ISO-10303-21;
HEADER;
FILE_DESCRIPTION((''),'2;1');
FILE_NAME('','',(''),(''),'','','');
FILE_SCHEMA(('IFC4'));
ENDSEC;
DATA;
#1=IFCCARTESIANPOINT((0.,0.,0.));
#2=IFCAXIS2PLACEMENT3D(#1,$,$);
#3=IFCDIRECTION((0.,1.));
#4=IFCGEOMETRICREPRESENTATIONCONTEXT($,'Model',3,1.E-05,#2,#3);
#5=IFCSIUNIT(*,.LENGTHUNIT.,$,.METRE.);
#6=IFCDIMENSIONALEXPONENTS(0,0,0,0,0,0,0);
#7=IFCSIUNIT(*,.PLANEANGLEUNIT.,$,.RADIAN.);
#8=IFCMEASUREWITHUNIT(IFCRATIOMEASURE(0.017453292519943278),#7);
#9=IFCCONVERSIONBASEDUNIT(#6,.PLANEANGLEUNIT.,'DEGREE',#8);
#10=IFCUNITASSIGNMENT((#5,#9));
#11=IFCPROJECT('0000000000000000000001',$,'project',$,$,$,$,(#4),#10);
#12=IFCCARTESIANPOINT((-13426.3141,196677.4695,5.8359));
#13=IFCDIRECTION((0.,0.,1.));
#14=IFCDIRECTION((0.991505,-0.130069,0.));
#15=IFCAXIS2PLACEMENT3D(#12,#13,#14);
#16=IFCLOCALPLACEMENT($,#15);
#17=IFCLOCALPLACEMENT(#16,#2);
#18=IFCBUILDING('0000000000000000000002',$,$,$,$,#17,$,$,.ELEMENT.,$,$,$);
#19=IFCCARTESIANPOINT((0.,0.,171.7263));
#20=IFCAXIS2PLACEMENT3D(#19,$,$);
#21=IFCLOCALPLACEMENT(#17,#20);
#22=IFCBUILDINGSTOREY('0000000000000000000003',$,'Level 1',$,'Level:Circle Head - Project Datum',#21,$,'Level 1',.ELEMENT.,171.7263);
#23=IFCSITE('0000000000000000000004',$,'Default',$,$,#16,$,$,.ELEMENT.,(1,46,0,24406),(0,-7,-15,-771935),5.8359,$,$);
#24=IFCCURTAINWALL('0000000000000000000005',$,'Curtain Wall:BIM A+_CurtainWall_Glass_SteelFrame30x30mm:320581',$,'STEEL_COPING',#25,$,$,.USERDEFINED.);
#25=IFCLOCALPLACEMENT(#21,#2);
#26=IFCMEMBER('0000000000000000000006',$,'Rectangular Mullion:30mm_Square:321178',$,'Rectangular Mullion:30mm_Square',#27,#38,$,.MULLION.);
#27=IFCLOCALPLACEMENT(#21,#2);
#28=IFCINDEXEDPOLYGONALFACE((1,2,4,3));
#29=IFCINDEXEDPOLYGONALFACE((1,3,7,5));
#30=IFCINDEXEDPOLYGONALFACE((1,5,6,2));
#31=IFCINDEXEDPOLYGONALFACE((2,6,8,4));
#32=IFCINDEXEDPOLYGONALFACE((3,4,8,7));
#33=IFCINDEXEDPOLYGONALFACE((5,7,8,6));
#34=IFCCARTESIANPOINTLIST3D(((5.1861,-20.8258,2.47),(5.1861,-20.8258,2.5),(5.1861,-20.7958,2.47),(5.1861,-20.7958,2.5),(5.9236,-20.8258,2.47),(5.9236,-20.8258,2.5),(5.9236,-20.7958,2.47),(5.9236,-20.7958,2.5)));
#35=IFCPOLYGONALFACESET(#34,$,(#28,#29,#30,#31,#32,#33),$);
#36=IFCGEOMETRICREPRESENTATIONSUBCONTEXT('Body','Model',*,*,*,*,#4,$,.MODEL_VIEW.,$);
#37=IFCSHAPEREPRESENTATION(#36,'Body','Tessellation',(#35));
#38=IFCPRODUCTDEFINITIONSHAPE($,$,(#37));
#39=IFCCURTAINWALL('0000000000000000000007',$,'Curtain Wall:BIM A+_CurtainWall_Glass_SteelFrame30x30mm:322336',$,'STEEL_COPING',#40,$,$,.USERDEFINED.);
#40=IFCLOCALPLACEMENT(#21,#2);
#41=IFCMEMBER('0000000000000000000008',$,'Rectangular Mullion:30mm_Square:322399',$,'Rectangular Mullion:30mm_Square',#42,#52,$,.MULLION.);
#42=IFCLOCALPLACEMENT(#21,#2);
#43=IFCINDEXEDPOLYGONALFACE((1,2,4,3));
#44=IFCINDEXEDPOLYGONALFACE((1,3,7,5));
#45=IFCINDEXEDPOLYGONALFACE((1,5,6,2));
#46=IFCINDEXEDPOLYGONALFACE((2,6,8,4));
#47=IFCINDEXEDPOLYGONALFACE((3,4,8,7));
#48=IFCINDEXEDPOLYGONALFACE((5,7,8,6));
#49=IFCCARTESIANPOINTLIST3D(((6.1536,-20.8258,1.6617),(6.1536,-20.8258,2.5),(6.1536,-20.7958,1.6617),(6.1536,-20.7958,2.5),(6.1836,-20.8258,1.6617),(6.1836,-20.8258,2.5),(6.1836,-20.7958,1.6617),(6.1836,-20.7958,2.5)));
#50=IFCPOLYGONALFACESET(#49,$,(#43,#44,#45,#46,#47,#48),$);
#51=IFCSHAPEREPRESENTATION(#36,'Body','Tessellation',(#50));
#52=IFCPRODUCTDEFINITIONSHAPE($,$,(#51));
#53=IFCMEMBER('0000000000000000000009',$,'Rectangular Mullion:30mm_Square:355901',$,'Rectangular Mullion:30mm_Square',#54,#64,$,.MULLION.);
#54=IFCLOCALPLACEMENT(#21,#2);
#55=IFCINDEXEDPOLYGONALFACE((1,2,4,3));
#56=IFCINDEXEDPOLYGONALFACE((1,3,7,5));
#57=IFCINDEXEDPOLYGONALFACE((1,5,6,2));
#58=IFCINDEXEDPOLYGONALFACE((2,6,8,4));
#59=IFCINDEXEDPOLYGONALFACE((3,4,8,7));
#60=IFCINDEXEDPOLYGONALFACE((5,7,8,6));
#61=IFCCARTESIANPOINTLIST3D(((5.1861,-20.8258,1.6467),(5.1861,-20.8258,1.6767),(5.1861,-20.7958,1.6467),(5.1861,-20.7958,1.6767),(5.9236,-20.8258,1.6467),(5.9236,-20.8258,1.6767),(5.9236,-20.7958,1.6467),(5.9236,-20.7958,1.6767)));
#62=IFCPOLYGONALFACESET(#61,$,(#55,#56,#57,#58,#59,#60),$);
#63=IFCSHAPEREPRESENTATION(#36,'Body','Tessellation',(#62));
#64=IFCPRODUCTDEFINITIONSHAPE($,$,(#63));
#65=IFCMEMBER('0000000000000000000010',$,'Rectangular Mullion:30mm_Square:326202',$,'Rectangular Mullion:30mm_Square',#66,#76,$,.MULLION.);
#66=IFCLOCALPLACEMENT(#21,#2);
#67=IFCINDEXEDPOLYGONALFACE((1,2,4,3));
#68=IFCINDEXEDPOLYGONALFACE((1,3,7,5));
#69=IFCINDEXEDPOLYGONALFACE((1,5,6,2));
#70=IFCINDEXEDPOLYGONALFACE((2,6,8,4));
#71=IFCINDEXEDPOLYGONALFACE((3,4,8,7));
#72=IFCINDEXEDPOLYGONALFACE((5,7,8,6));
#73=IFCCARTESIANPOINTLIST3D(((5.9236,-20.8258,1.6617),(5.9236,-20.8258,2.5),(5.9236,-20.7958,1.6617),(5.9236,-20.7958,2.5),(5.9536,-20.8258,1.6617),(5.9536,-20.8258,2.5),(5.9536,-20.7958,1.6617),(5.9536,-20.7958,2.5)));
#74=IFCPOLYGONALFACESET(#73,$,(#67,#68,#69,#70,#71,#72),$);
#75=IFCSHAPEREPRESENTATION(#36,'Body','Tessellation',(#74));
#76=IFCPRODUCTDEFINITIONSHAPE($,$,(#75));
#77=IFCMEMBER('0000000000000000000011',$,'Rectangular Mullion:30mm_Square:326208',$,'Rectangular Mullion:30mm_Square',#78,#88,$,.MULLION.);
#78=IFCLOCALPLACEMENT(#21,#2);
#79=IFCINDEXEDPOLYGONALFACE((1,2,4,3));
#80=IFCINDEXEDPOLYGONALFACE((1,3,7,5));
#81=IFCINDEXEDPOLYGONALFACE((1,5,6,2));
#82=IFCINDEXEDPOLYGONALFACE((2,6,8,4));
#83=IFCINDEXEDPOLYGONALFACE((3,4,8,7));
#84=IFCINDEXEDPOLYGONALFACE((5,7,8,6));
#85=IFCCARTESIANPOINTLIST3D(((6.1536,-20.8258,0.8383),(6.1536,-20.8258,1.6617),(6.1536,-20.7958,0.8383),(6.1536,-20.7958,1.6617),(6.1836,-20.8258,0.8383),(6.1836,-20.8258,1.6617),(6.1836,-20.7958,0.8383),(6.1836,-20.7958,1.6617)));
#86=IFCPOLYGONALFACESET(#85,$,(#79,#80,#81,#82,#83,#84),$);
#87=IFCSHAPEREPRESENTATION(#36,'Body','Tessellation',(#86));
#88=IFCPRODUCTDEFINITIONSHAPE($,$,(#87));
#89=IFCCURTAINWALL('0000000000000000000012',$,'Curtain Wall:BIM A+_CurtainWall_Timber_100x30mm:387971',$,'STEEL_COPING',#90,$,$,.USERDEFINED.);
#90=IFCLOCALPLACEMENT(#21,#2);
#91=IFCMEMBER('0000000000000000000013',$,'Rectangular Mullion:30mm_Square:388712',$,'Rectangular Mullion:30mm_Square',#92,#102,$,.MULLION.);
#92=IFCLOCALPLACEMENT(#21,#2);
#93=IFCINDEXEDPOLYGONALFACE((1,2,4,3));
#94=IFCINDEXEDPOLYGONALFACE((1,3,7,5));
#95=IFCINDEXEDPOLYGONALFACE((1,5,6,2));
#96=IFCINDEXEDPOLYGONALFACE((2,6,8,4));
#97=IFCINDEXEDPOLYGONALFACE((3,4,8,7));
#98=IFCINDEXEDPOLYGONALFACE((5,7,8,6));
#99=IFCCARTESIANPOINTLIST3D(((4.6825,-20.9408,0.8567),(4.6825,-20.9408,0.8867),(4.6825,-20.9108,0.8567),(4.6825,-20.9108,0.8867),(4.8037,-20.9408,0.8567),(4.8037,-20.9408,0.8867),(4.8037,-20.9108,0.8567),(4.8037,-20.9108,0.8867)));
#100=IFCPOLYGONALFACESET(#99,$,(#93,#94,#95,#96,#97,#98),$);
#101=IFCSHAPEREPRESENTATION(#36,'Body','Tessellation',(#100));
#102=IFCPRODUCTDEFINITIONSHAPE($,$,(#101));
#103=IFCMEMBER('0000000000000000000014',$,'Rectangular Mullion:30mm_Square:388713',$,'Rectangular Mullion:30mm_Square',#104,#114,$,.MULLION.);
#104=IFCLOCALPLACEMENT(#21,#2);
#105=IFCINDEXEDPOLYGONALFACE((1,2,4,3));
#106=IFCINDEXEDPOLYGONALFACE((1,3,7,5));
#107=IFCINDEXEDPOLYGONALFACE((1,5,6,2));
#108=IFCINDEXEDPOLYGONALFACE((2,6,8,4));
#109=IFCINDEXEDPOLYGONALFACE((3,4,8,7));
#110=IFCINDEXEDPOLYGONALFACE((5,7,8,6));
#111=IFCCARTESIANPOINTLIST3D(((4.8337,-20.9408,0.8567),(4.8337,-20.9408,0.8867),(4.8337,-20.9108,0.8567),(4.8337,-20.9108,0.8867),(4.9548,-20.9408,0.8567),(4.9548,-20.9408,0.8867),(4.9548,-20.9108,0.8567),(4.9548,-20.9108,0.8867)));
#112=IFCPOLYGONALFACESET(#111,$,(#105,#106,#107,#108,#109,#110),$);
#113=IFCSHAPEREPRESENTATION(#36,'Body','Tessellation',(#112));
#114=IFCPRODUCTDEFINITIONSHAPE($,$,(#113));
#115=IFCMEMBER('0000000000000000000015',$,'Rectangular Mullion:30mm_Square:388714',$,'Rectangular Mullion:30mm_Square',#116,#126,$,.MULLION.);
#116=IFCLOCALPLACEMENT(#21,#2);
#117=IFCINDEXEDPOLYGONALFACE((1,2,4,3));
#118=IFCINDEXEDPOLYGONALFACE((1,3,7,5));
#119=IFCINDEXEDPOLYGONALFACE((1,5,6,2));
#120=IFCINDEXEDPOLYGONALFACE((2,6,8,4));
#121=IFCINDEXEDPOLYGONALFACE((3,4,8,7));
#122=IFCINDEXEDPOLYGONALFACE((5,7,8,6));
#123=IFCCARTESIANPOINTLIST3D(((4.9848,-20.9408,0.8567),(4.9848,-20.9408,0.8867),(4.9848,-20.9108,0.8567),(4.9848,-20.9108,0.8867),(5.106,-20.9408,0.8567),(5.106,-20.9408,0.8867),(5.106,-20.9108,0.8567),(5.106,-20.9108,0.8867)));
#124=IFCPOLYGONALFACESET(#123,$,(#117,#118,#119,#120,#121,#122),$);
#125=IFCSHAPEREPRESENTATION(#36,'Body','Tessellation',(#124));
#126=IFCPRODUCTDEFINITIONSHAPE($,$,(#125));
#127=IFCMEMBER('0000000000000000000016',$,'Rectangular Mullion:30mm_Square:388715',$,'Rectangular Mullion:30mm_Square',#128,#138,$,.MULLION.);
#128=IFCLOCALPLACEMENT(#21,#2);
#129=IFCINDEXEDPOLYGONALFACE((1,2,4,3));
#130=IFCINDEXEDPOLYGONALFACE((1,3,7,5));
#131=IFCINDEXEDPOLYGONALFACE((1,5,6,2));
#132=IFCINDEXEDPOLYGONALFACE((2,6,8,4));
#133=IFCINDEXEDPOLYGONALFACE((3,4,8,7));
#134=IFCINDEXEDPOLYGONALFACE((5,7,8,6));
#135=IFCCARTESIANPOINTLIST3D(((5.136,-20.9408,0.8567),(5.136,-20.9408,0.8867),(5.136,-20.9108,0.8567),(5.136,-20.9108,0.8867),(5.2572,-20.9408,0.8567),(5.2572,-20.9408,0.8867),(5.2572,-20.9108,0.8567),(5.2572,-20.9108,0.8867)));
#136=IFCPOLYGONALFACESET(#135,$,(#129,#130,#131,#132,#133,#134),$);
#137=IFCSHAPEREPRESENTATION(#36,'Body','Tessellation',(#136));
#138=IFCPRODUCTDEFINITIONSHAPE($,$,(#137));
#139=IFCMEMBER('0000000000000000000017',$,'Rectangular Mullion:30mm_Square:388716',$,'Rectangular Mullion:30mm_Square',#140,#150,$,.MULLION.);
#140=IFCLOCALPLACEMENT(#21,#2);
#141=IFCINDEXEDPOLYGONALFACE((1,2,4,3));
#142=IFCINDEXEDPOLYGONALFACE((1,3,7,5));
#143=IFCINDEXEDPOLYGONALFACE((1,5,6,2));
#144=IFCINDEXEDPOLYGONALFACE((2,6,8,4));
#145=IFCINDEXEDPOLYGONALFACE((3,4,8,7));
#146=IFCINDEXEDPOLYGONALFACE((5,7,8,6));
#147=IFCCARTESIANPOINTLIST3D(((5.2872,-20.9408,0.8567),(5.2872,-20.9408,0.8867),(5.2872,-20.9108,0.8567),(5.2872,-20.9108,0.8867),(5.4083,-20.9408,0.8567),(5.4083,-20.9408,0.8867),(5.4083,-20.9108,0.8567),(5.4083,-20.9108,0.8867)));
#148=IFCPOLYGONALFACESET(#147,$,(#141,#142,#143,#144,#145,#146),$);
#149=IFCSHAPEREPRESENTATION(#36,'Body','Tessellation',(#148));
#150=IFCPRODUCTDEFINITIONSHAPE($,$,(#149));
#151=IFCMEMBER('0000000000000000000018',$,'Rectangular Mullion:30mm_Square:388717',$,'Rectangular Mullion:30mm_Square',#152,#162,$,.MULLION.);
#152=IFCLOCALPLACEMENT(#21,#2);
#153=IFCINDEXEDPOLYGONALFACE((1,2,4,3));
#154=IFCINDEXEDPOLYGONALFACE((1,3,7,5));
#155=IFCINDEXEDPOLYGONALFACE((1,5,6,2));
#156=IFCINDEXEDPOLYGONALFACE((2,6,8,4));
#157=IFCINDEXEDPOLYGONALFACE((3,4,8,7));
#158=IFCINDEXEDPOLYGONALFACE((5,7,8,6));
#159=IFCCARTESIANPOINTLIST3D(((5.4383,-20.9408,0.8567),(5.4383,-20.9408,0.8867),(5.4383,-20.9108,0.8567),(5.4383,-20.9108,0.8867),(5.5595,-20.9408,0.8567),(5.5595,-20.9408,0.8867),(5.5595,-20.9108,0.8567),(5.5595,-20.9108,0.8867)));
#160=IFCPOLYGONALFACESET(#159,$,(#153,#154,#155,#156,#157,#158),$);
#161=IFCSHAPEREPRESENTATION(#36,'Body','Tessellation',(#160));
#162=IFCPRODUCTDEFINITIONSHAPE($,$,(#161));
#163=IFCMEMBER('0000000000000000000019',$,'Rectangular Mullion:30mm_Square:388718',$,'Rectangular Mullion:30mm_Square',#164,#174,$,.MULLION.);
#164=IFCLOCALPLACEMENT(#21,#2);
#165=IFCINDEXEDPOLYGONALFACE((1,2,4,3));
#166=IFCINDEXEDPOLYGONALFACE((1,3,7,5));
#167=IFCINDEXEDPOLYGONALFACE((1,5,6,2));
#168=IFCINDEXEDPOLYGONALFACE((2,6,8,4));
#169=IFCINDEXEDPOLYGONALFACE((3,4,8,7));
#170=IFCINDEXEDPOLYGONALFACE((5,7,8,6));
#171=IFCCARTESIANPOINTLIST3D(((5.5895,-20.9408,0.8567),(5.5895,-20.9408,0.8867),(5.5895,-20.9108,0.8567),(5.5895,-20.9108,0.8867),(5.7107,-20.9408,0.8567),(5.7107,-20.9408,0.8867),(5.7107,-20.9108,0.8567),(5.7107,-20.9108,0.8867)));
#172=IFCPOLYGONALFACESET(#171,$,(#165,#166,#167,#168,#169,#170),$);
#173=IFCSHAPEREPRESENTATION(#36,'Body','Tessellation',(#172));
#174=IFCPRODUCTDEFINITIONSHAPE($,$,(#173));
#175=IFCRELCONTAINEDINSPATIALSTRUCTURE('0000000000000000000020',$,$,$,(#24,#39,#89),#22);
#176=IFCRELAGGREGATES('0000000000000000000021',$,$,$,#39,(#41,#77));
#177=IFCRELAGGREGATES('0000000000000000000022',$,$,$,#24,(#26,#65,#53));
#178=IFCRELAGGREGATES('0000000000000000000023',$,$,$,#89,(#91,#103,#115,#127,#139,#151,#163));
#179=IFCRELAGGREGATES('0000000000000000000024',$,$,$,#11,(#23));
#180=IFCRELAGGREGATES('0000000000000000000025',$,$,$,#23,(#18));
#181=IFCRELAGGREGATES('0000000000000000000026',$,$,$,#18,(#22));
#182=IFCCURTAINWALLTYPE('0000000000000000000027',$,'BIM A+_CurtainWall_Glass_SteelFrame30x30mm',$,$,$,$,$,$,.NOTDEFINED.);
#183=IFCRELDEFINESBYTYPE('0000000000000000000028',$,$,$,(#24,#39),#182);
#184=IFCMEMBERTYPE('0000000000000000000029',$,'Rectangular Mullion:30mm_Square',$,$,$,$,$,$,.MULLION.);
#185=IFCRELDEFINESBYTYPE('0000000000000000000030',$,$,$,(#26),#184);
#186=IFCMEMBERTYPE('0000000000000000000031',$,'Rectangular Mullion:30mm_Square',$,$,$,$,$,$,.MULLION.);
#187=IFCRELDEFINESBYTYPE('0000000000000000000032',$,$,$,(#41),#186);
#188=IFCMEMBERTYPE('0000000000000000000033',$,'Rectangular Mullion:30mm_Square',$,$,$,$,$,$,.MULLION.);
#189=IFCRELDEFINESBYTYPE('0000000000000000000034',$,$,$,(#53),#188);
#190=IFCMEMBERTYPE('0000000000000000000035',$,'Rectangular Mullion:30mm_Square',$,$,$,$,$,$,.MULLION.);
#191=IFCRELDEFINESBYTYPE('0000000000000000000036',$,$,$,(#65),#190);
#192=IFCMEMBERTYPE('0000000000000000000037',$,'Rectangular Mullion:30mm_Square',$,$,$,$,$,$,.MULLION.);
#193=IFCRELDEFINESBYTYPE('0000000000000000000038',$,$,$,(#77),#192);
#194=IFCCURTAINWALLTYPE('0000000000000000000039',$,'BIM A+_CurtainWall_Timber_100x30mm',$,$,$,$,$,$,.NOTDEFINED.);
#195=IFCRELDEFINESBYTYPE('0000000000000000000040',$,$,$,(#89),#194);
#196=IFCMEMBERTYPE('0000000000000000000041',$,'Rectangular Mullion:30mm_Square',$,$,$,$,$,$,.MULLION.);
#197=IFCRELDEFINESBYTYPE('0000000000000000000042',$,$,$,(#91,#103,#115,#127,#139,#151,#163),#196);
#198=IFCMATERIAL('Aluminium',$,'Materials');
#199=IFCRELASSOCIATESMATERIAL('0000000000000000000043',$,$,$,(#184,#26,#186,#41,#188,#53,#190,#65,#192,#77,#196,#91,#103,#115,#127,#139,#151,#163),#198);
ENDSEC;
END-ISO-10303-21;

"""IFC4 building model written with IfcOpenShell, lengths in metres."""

from ifc_helpers import new_model, entity, si_unit, converted_unit, direction, frame, origin, place, context, subcontext, project, spatial, indexed_curve, outline, extrude, source, transform, mapped, material, type_object, type_shapes, element, aggregate, save


model = new_model("IFC4")

# Units and contexts
model_context = context("Model", 3, precision=1e-05, world=origin(), true_north=direction((0.0, 1.0)))
body_context = subcontext(model_context, "Body", "Model", "MODEL_VIEW")
ifc_project = project(units=[si_unit("LENGTHUNIT", "METRE"), converted_unit("PLANEANGLEUNIT", "DEGREE", entity("IfcRatioMeasure", 0.017453292519943278), si_unit("PLANEANGLEUNIT", "RADIAN"), dimensions=[0, 0, 0, 0, 0, 0, 0])], contexts=[model_context])

# Site, building, storey
site_placement = place(None, frame((-13426.3141, 196677.4695, 5.8359), z_axis=(0.0, 0.0, 1.0), x_axis=(0.991505, -0.130069, 0.0)))
site = spatial("IfcSite", under=ifc_project, at=site_placement, Name="Default", CompositionType="ELEMENT", RefLatitude=(1, 46, 0, 24406), RefLongitude=(0, -7, -15, -771935), RefElevation=5.8359)
building_placement = place(site_placement, origin())
building = spatial("IfcBuilding", under=site, at=building_placement, CompositionType="ELEMENT")
storey_placement = place(building_placement, frame((0.0, 0.0, 171.7263)))
storey = spatial("IfcBuildingStorey", under=building, at=storey_placement, Name="Level 1", ObjectType="Level:Circle Head - Project Datum", LongName="Level 1", CompositionType="ELEMENT", Elevation=171.7263)

# Curtain walls, members
curtain_wall_type_1 = type_object("IfcCurtainWallType", Name="BIM A+_CurtainWall_Glass_SteelFrame30x30mm", PredefinedType="NOTDEFINED")
curtain_wall_1_placement = place(storey_placement, frame((0.0, 0.0, -171.7263)))
curtain_wall_1 = element("IfcCurtainWall", 1, at=curtain_wall_1_placement, inside=storey, type_object=curtain_wall_type_1, Name="Curtain Wall:BIM A+_CurtainWall_Glass_SteelFrame30x30mm:320581", ObjectType="STEEL_COPING", PredefinedType="USERDEFINED")
ifc_material_1 = material(Name="Aluminium", Category="Materials")
member_type_1 = type_object("IfcMemberType", Name="Rectangular Mullion:30mm_Square", PredefinedType="MULLION", material=ifc_material_1)
shared_shape_1 = source(origin(), body_context, "Body", "SweptSolid", [
    extrude(outline(indexed_curve([(-0.015, -0.015), (0.015, -0.015), (0.015, 0.015), (-0.015, 0.015), (-0.015, -0.015)], self_intersect=False)), frame((-0.015, 0.0, -0.7375), z_axis=(0.0, 0.0, 1.0), x_axis=(0.0, -1.0, 0.0)), (0.0, 0.0, 1.0), 0.7375),
])
type_shapes(member_type_1, [shared_shape_1])
member_1_placement = place(curtain_wall_1_placement, frame((5.9236, -20.8108, 174.2263), z_axis=(1.0, 0.0, 0.0), x_axis=(0.0, 0.0, 1.0)))
member_1 = element("IfcMember", 2, at=member_1_placement, type_object=member_type_1, material=ifc_material_1, Name="Rectangular Mullion:30mm_Square:321178", ObjectType="Rectangular Mullion:30mm_Square", PredefinedType="MULLION", context=body_context, shape_type="MappedRepresentation", body=[
    mapped(shared_shape_1, transform((0.0, 0.0, 0.0), scale=1.0)),
])
curtain_wall_2_placement = place(storey_placement, frame((0.0, 0.0, -171.7263)))
curtain_wall_2 = element("IfcCurtainWall", 3, at=curtain_wall_2_placement, inside=storey, type_object=curtain_wall_type_1, Name="Curtain Wall:BIM A+_CurtainWall_Glass_SteelFrame30x30mm:322336", ObjectType="STEEL_COPING", PredefinedType="USERDEFINED")
member_type_2 = type_object("IfcMemberType", Name="Rectangular Mullion:30mm_Square", PredefinedType="MULLION", material=ifc_material_1)
shared_shape_2 = source(origin(), body_context, "Body", "SweptSolid", [
    extrude(outline(indexed_curve([(-0.015, -0.015), (0.015, -0.015), (0.015, 0.015), (-0.015, 0.015), (-0.015, -0.015)], self_intersect=False)), frame((-0.015, 0.0, -0.8383), z_axis=(0.0, 0.0, 1.0), x_axis=(0.0, -1.0, 0.0)), (0.0, 0.0, 1.0), 0.8383),
])
type_shapes(member_type_2, [shared_shape_2])
member_2_placement = place(curtain_wall_2_placement, frame((6.1536, -20.8108, 174.2263), z_axis=(0.0, 0.0, 1.0), x_axis=(-1.0, 0.0, 0.0)))
member_2 = element("IfcMember", 4, at=member_2_placement, type_object=member_type_2, material=ifc_material_1, Name="Rectangular Mullion:30mm_Square:322399", ObjectType="Rectangular Mullion:30mm_Square", PredefinedType="MULLION", context=body_context, shape_type="MappedRepresentation", body=[
    mapped(shared_shape_2, transform((0.0, 0.0, 0.0), scale=1.0)),
])

# Members
member_type_3 = type_object("IfcMemberType", Name="Rectangular Mullion:30mm_Square", PredefinedType="MULLION", material=ifc_material_1)
shared_shape_3 = source(origin(), body_context, "Body", "SweptSolid", [
    extrude(outline(indexed_curve([(-0.015, -0.015), (0.015, -0.015), (0.015, 0.015), (-0.015, 0.015), (-0.015, -0.015)], self_intersect=False)), frame((0.0, 0.0, -0.7375), z_axis=(0.0, 0.0, 1.0), x_axis=(0.0, -1.0, 0.0)), (0.0, 0.0, 1.0), 0.7375),
])
type_shapes(member_type_3, [shared_shape_3])
member_3_placement = place(curtain_wall_1_placement, frame((5.9236, -20.8108, 173.3879), z_axis=(1.0, 0.0, 0.0), x_axis=(0.0, 0.0, 1.0)))
member_3 = element("IfcMember", 5, at=member_3_placement, type_object=member_type_3, material=ifc_material_1, Name="Rectangular Mullion:30mm_Square:355901", ObjectType="Rectangular Mullion:30mm_Square", PredefinedType="MULLION", context=body_context, shape_type="MappedRepresentation", body=[
    mapped(shared_shape_3, transform((0.0, 0.0, 0.0), scale=1.0)),
])
member_type_4 = type_object("IfcMemberType", Name="Rectangular Mullion:30mm_Square", PredefinedType="MULLION", material=ifc_material_1)
shared_shape_4 = source(origin(), body_context, "Body", "SweptSolid", [
    extrude(outline(indexed_curve([(-0.015, -0.015), (0.015, -0.015), (0.015, 0.015), (-0.015, 0.015), (-0.015, -0.015)], self_intersect=False)), frame((-0.015, 0.0, -0.8383), z_axis=(0.0, 0.0, 1.0), x_axis=(0.0, -1.0, 0.0)), (0.0, 0.0, 1.0), 0.8383),
])
type_shapes(member_type_4, [shared_shape_4])
member_4_placement = place(curtain_wall_1_placement, frame((5.9536, -20.8108, 173.3879), z_axis=(0.0, 0.0, -1.0), x_axis=(1.0, 0.0, 0.0)))
member_4 = element("IfcMember", 6, at=member_4_placement, type_object=member_type_4, material=ifc_material_1, Name="Rectangular Mullion:30mm_Square:326202", ObjectType="Rectangular Mullion:30mm_Square", PredefinedType="MULLION", context=body_context, shape_type="MappedRepresentation", body=[
    mapped(shared_shape_4, transform((0.0, 0.0, 0.0), scale=1.0)),
])
member_type_5 = type_object("IfcMemberType", Name="Rectangular Mullion:30mm_Square", PredefinedType="MULLION", material=ifc_material_1)
shared_shape_5 = source(origin(), body_context, "Body", "SweptSolid", [
    extrude(outline(indexed_curve([(-0.015, -0.015), (0.015, -0.015), (0.015, 0.015), (-0.015, 0.015), (-0.015, -0.015)], self_intersect=False)), frame((-0.015, 0.0, -0.8233), z_axis=(0.0, 0.0, 1.0), x_axis=(0.0, -1.0, 0.0)), (0.0, 0.0, 1.0), 0.8233),
])
type_shapes(member_type_5, [shared_shape_5])
member_5_placement = place(curtain_wall_2_placement, frame((6.1536, -20.8108, 173.3879), z_axis=(0.0, 0.0, 1.0), x_axis=(-1.0, 0.0, 0.0)))
member_5 = element("IfcMember", 7, at=member_5_placement, type_object=member_type_5, material=ifc_material_1, Name="Rectangular Mullion:30mm_Square:326208", ObjectType="Rectangular Mullion:30mm_Square", PredefinedType="MULLION", context=body_context, shape_type="MappedRepresentation", body=[
    mapped(shared_shape_5, transform((0.0, 0.0, 0.0), scale=1.0)),
])
aggregate(curtain_wall_2, [member_2, member_5])

# Curtain wall, members
curtain_wall_type_2 = type_object("IfcCurtainWallType", Name="BIM A+_CurtainWall_Timber_100x30mm", PredefinedType="NOTDEFINED")
curtain_wall_3_placement = place(storey_placement, frame((0.0, 0.0, -171.7263)))
curtain_wall_3 = element("IfcCurtainWall", 8, at=curtain_wall_3_placement, inside=storey, type_object=curtain_wall_type_2, Name="Curtain Wall:BIM A+_CurtainWall_Timber_100x30mm:387971", ObjectType="STEEL_COPING", PredefinedType="USERDEFINED")
member_type_6 = type_object("IfcMemberType", Name="Rectangular Mullion:30mm_Square", PredefinedType="MULLION", material=ifc_material_1)
shared_shape_6 = source(origin(), body_context, "Body", "SweptSolid", [
    extrude(outline(indexed_curve([(-0.015, -0.015), (0.015, -0.015), (0.015, 0.015), (-0.015, 0.015), (-0.015, -0.015)], self_intersect=False)), frame((0.0, 0.0, -0.1212), z_axis=(0.0, 0.0, 1.0), x_axis=(0.0, -1.0, 0.0)), (0.0, 0.0, 1.0), 0.1212),
])
type_shapes(member_type_6, [shared_shape_6])
member_6_placement = place(curtain_wall_3_placement, frame((4.8037, -20.9258, 172.598), z_axis=(1.0, 0.0, 0.0), x_axis=(0.0, 0.0, 1.0)))
member_6 = element("IfcMember", 9, at=member_6_placement, type_object=member_type_6, material=ifc_material_1, Name="Rectangular Mullion:30mm_Square:388712", ObjectType="Rectangular Mullion:30mm_Square", PredefinedType="MULLION", context=body_context, shape_type="MappedRepresentation", body=[
    mapped(shared_shape_6, transform((0.0, 0.0, 0.0), scale=1.0)),
])
member_7_placement = place(curtain_wall_3_placement, frame((4.9548, -20.9258, 172.598), z_axis=(1.0, 0.0, 0.0), x_axis=(0.0, 0.0, 1.0)))
member_7 = element("IfcMember", 10, at=member_7_placement, type_object=member_type_6, material=ifc_material_1, Name="Rectangular Mullion:30mm_Square:388713", ObjectType="Rectangular Mullion:30mm_Square", PredefinedType="MULLION", context=body_context, shape_type="MappedRepresentation", body=[
    mapped(shared_shape_6, transform((0.0, 0.0, 0.0), scale=1.0)),
])
member_8_placement = place(curtain_wall_3_placement, frame((5.106, -20.9258, 172.598), z_axis=(1.0, 0.0, 0.0), x_axis=(0.0, 0.0, 1.0)))
member_8 = element("IfcMember", 11, at=member_8_placement, type_object=member_type_6, material=ifc_material_1, Name="Rectangular Mullion:30mm_Square:388714", ObjectType="Rectangular Mullion:30mm_Square", PredefinedType="MULLION", context=body_context, shape_type="MappedRepresentation", body=[
    mapped(shared_shape_6, transform((0.0, 0.0, 0.0), scale=1.0)),
])
member_9_placement = place(curtain_wall_3_placement, frame((5.2572, -20.9258, 172.598), z_axis=(1.0, 0.0, 0.0), x_axis=(0.0, 0.0, 1.0)))
member_9 = element("IfcMember", 12, at=member_9_placement, type_object=member_type_6, material=ifc_material_1, Name="Rectangular Mullion:30mm_Square:388715", ObjectType="Rectangular Mullion:30mm_Square", PredefinedType="MULLION", context=body_context, shape_type="MappedRepresentation", body=[
    mapped(shared_shape_6, transform((0.0, 0.0, 0.0), scale=1.0)),
])
member_10_placement = place(curtain_wall_3_placement, frame((5.4083, -20.9258, 172.598), z_axis=(1.0, 0.0, 0.0), x_axis=(0.0, 0.0, 1.0)))
member_10 = element("IfcMember", 13, at=member_10_placement, type_object=member_type_6, material=ifc_material_1, Name="Rectangular Mullion:30mm_Square:388716", ObjectType="Rectangular Mullion:30mm_Square", PredefinedType="MULLION", context=body_context, shape_type="MappedRepresentation", body=[
    mapped(shared_shape_6, transform((0.0, 0.0, 0.0), scale=1.0)),
])
member_11_placement = place(curtain_wall_3_placement, frame((5.5595, -20.9258, 172.598), z_axis=(1.0, 0.0, 0.0), x_axis=(0.0, 0.0, 1.0)))
member_11 = element("IfcMember", 14, at=member_11_placement, type_object=member_type_6, material=ifc_material_1, Name="Rectangular Mullion:30mm_Square:388717", ObjectType="Rectangular Mullion:30mm_Square", PredefinedType="MULLION", context=body_context, shape_type="MappedRepresentation", body=[
    mapped(shared_shape_6, transform((0.0, 0.0, 0.0), scale=1.0)),
])
member_12_placement = place(curtain_wall_3_placement, frame((5.7107, -20.9258, 172.598), z_axis=(1.0, 0.0, 0.0), x_axis=(0.0, 0.0, 1.0)))
member_12 = element("IfcMember", 15, at=member_12_placement, type_object=member_type_6, material=ifc_material_1, Name="Rectangular Mullion:30mm_Square:388718", ObjectType="Rectangular Mullion:30mm_Square", PredefinedType="MULLION", context=body_context, shape_type="MappedRepresentation", body=[
    mapped(shared_shape_6, transform((0.0, 0.0, 0.0), scale=1.0)),
])

aggregate(curtain_wall_1, [member_1, member_4, member_3])
aggregate(curtain_wall_3, [member_6, member_7, member_8, member_9, member_10, member_11, member_12])

save(model, "model.ifc")
